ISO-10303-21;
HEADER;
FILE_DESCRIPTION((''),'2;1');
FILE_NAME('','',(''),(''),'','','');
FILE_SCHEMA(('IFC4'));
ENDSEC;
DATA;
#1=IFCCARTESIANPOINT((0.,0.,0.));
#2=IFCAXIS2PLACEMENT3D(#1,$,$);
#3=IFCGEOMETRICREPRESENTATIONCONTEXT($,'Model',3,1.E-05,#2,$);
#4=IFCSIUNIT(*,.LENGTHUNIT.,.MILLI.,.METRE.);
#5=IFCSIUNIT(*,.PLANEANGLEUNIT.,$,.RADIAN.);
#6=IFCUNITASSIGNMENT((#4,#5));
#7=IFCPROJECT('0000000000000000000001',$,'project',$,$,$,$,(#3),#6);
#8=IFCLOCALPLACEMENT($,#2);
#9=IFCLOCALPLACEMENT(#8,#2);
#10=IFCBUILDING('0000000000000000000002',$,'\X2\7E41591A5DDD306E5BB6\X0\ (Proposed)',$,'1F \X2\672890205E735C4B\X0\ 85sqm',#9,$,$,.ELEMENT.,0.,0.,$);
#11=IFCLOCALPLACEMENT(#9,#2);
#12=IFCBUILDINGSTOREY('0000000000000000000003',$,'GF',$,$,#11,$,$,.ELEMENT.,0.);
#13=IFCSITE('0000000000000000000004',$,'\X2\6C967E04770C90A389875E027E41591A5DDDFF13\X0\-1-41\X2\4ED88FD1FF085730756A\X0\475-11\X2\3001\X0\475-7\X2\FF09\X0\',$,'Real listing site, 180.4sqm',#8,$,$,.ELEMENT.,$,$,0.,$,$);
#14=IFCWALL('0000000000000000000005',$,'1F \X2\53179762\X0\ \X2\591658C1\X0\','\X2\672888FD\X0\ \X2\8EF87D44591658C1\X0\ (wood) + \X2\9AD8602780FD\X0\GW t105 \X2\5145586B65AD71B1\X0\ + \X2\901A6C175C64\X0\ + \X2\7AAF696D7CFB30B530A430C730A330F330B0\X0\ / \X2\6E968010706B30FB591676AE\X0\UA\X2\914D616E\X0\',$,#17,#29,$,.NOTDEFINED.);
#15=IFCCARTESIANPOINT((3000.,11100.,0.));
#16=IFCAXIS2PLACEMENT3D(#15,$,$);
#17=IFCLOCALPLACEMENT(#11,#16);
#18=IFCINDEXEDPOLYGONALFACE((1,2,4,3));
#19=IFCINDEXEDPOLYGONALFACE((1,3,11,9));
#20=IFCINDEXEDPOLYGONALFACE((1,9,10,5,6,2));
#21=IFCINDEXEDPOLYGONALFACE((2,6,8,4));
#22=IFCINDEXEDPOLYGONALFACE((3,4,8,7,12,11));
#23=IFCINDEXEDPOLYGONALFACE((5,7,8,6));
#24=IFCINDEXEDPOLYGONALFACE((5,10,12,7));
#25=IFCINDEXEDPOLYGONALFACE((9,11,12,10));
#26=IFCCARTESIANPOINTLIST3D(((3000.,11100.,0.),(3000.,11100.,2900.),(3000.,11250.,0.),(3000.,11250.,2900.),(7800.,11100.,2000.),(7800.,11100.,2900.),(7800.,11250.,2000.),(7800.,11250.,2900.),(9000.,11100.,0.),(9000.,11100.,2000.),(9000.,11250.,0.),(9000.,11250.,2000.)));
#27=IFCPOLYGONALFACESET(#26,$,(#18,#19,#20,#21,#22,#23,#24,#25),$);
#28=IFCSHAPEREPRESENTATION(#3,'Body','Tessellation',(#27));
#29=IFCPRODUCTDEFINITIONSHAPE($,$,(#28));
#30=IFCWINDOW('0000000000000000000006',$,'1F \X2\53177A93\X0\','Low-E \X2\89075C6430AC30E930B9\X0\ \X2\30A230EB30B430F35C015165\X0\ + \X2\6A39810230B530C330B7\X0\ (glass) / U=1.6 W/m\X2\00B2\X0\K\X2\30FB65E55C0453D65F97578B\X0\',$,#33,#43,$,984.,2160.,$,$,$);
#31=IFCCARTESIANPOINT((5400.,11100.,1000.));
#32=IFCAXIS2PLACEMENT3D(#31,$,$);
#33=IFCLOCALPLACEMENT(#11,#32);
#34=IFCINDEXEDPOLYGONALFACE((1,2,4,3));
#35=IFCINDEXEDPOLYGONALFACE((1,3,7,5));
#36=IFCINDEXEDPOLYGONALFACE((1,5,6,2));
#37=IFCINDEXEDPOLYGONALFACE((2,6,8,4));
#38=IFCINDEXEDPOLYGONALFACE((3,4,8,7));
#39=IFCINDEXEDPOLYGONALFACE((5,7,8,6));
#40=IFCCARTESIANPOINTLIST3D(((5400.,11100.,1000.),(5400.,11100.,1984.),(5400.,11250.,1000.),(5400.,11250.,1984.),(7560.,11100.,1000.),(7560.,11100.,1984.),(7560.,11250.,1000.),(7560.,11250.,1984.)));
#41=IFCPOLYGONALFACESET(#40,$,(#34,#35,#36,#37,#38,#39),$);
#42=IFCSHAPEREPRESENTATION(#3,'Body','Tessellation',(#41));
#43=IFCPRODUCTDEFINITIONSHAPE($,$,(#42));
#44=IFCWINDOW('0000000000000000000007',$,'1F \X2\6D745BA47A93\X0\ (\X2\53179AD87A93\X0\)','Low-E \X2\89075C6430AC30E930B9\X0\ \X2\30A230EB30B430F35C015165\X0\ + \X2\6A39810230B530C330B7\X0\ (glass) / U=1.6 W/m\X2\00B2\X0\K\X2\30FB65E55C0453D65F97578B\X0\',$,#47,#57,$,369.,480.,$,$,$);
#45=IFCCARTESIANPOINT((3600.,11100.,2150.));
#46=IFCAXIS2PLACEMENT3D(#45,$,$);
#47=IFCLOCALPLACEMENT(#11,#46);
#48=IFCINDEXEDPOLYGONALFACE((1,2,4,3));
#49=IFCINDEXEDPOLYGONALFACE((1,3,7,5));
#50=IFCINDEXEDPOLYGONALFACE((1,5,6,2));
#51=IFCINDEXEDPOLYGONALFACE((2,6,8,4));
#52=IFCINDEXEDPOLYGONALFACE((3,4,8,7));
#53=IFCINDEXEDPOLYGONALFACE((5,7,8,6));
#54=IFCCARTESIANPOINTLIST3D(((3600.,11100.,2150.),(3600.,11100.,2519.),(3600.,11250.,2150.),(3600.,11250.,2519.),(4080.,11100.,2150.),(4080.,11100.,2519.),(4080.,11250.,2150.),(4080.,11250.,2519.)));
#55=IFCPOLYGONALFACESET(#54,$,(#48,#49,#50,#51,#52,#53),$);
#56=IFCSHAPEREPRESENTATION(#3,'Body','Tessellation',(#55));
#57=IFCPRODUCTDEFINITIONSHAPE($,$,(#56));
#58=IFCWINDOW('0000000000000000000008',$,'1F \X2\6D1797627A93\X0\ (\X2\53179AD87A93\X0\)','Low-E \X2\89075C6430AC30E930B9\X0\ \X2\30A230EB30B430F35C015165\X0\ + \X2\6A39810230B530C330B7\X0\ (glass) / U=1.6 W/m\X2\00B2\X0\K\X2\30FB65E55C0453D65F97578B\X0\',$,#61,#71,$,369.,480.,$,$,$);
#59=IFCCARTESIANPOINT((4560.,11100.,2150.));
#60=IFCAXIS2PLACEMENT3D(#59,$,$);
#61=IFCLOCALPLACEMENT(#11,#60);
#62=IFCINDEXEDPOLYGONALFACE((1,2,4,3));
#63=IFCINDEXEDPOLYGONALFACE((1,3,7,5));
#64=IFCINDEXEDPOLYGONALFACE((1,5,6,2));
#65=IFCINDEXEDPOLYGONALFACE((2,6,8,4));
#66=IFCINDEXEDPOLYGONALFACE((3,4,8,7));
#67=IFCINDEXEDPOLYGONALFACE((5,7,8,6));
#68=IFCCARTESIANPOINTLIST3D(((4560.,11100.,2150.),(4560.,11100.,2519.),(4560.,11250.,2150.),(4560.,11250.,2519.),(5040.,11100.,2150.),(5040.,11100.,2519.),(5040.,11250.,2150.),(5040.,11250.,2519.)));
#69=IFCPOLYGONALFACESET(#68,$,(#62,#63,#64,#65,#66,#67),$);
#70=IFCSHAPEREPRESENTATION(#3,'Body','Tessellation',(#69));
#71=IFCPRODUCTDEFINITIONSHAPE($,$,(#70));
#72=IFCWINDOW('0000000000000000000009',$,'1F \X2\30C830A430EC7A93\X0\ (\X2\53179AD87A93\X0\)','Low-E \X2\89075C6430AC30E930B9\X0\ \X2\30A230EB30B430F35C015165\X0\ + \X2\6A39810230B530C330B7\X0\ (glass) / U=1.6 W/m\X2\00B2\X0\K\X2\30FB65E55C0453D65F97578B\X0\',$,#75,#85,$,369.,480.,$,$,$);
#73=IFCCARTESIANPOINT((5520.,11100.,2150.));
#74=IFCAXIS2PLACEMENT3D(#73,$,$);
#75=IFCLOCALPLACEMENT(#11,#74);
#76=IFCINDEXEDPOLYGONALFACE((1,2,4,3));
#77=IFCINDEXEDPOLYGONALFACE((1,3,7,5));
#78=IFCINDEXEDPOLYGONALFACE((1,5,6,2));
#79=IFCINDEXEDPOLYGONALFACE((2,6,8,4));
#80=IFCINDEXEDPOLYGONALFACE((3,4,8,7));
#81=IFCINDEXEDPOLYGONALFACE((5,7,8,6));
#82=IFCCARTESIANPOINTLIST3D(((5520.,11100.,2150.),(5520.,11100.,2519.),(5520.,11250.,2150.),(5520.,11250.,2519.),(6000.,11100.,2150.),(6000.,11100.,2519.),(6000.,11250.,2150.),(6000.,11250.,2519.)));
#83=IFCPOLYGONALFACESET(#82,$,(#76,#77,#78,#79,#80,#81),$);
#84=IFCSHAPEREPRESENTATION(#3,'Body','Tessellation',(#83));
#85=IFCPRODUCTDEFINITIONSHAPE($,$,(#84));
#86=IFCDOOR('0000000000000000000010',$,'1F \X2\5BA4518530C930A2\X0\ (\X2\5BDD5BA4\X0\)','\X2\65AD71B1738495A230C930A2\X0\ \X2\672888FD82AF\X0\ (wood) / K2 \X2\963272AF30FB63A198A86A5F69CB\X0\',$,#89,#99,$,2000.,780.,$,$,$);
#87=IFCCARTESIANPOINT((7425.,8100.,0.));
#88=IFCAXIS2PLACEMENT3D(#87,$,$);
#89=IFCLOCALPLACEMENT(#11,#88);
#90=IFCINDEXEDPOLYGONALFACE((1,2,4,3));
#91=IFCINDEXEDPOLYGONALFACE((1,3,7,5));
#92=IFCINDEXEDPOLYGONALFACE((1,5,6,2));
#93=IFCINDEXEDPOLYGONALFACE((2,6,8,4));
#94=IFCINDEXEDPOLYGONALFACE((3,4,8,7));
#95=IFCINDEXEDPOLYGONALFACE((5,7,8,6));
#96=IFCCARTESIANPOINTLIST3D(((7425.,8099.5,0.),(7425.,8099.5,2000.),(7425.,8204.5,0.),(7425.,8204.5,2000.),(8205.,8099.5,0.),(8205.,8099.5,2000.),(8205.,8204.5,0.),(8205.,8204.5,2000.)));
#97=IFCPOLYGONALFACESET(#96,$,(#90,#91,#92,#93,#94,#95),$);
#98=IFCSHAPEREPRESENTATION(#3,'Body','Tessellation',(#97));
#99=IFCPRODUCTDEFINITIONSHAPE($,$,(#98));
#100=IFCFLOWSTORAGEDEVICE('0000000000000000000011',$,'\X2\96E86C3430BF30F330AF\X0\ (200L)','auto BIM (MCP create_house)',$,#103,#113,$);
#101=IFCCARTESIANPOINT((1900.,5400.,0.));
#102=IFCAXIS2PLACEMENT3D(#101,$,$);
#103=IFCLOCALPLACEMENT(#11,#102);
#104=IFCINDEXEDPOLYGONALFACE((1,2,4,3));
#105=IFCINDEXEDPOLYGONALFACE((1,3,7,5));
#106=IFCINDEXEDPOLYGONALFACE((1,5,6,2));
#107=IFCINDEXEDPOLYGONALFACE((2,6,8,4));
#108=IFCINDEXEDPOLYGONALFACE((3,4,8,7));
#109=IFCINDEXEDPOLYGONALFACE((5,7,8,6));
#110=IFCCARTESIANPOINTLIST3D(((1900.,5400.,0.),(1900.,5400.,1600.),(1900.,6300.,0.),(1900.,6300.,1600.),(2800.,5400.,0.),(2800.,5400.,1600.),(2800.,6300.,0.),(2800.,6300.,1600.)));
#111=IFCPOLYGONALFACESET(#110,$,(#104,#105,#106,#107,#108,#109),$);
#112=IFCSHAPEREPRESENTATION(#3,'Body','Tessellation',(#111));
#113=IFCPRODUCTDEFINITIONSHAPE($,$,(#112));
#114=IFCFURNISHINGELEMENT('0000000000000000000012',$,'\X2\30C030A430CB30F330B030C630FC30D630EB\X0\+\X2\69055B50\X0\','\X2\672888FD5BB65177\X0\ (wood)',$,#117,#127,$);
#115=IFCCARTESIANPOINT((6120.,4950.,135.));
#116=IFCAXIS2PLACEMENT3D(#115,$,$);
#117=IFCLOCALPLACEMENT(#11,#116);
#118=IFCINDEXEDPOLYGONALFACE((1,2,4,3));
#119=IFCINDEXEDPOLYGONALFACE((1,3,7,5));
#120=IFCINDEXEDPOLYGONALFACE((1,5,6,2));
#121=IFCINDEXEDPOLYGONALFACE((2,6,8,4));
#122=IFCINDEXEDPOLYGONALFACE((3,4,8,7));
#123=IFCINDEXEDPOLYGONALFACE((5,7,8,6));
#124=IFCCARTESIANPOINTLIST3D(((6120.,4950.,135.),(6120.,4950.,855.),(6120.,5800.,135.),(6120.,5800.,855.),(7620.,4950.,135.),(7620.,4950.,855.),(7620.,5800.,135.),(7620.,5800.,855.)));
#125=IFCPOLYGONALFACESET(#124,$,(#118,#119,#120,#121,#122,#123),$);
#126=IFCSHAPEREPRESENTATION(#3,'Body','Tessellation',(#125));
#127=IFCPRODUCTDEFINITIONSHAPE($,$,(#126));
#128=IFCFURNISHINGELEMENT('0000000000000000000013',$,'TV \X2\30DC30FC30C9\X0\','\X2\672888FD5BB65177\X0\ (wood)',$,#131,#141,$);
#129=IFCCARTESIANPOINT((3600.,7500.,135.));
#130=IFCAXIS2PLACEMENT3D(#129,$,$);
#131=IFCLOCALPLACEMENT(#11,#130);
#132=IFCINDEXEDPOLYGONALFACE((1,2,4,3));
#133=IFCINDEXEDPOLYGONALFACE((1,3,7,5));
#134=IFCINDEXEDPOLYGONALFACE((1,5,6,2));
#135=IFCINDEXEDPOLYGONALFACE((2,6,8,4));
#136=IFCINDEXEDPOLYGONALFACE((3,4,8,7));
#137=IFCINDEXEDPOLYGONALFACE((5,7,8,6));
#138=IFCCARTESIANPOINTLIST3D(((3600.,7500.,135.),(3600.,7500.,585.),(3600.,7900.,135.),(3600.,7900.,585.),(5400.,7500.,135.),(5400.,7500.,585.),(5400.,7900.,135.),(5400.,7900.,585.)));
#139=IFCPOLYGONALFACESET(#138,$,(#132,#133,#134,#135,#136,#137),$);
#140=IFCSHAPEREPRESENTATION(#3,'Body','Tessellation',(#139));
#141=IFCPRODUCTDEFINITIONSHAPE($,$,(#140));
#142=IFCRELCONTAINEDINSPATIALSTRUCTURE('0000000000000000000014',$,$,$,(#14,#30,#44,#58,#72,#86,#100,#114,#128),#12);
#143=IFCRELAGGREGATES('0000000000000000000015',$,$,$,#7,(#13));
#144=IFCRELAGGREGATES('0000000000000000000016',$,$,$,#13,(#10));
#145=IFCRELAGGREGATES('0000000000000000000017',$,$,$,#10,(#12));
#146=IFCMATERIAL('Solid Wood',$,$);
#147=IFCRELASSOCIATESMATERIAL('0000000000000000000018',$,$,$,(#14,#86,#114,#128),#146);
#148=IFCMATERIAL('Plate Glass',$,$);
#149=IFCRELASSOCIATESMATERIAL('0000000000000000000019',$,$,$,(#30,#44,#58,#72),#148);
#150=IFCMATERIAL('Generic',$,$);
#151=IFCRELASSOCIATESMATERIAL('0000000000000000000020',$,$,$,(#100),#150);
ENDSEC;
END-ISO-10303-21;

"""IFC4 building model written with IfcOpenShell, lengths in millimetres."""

from ifc_helpers import new_model, si_unit, frame, frame_2d, origin, place, context, project, spatial, rectangle, extrude, material, element, fill, save


model = new_model("IFC4")

# Units and contexts
model_context = context("Model", 3, precision=1e-05, world=origin())
ifc_project = project(units=[si_unit("LENGTHUNIT", "METRE", prefix="MILLI"), si_unit("PLANEANGLEUNIT", "RADIAN")], contexts=[model_context])

# Site, building, storey
site_placement = place(None, origin())
site = spatial("IfcSite", under=ifc_project, at=site_placement, Name="沖縄県那覇市繁多川３-1-41付近（地番475-11、475-7）", ObjectType="Real listing site, 180.4sqm", CompositionType="ELEMENT", RefElevation=0.0)
building_placement = place(site_placement, origin())
building = spatial("IfcBuilding", under=site, at=building_placement, Name="繁多川の家 (Proposed)", ObjectType="1F 木造平屋 85sqm", CompositionType="ELEMENT", ElevationOfRefHeight=0.0, ElevationOfTerrain=0.0)
storey_placement = place(building_placement, origin())
storey = spatial("IfcBuildingStorey", under=building, at=storey_placement, Name="GF", CompositionType="ELEMENT", Elevation=0.0)

# Wall, openings, windows
ifc_material_1 = material(Name="Solid Wood")
wall_1_placement = place(storey_placement, frame((3000.0, 11100.0, 0.0)))
wall_1 = element("IfcWall", 1, at=wall_1_placement, inside=storey, material=ifc_material_1, Name="1F 北面 外壁", Description="木製 軸組外壁 (wood) + 高性能GW t105 充填断熱 + 通気層 + 窯業系サイディング / 準耐火・外皮UA配慮", PredefinedType="NOTDEFINED", context=model_context, shape_type="SweptSolid", body=[
    extrude(rectangle(XDim=6000.0, YDim=150.0, at=frame_2d((3000.0, 75.0))), frame((3000.0, 11100.0, 0.0)), (0.0, 0.0, 1.0), 2900.0),
])
opening_1_placement = place(storey_placement, frame((5400.0, 11100.0, 1000.0)))
opening_1 = element("IfcOpeningElement", 2, at=opening_1_placement, cuts=wall_1, PredefinedType="NOTDEFINED", context=model_context, shape_type="SweptSolid", body=[
    extrude(rectangle(XDim=2160.0, YDim=150.0, at=frame_2d((1080.0, 75.0))), frame((5400.0, 11100.0, 1000.0)), (0.0, 0.0, 1.0), 984.0),
])
opening_2_placement = place(storey_placement, frame((3600.0, 11100.0, 2150.0)))
opening_2 = element("IfcOpeningElement", 3, at=opening_2_placement, cuts=wall_1, PredefinedType="NOTDEFINED", context=model_context, shape_type="SweptSolid", body=[
    extrude(rectangle(XDim=480.0, YDim=150.0, at=frame_2d((240.0, 75.0))), frame((3600.0, 11100.0, 2150.0)), (0.0, 0.0, 1.0), 369.0),
])
opening_3_placement = place(storey_placement, frame((4560.0, 11100.0, 2150.0)))
opening_3 = element("IfcOpeningElement", 4, at=opening_3_placement, cuts=wall_1, PredefinedType="NOTDEFINED", context=model_context, shape_type="SweptSolid", body=[
    extrude(rectangle(XDim=480.0, YDim=150.0, at=frame_2d((240.0, 75.0))), frame((4560.0, 11100.0, 2150.0)), (0.0, 0.0, 1.0), 369.0),
])
opening_4_placement = place(storey_placement, frame((5520.0, 11100.0, 2150.0)))
opening_4 = element("IfcOpeningElement", 5, at=opening_4_placement, cuts=wall_1, PredefinedType="NOTDEFINED", context=model_context, shape_type="SweptSolid", body=[
    extrude(rectangle(XDim=480.0, YDim=150.0, at=frame_2d((240.0, 75.0))), frame((5520.0, 11100.0, 2150.0)), (0.0, 0.0, 1.0), 369.0),
])
ifc_material_2 = material(Name="Plate Glass")
window_1_placement = place(storey_placement, frame((5400.0, 11100.0, 1000.0)))
window_1 = element("IfcWindow", 6, at=window_1_placement, inside=storey, material=ifc_material_2, Name="1F 北窓", Description="Low-E 複層ガラス アルゴン封入 + 樹脂サッシ (glass) / U=1.6 W/m²K・日射取得型", OverallHeight=984.0, OverallWidth=2160.0, context=model_context, shape_type="SweptSolid", body=[
    extrude(rectangle(XDim=2160.0, YDim=150.0, at=frame_2d((1080.0, 75.0))), frame((5400.0, 11100.0, 1000.0)), (0.0, 0.0, 1.0), 984.0),
])
fill(opening_1, window_1)
window_2_placement = place(storey_placement, frame((3600.0, 11100.0, 2150.0)))
window_2 = element("IfcWindow", 7, at=window_2_placement, inside=storey, material=ifc_material_2, Name="1F 浴室窓 (北高窓)", Description="Low-E 複層ガラス アルゴン封入 + 樹脂サッシ (glass) / U=1.6 W/m²K・日射取得型", OverallHeight=369.0, OverallWidth=480.0, context=model_context, shape_type="SweptSolid", body=[
    extrude(rectangle(XDim=480.0, YDim=150.0, at=frame_2d((240.0, 75.0))), frame((3600.0, 11100.0, 2150.0)), (0.0, 0.0, 1.0), 369.0),
])
fill(opening_2, window_2)
window_3_placement = place(storey_placement, frame((4560.0, 11100.0, 2150.0)))
window_3 = element("IfcWindow", 8, at=window_3_placement, inside=storey, material=ifc_material_2, Name="1F 洗面窓 (北高窓)", Description="Low-E 複層ガラス アルゴン封入 + 樹脂サッシ (glass) / U=1.6 W/m²K・日射取得型", OverallHeight=369.0, OverallWidth=480.0, context=model_context, shape_type="SweptSolid", body=[
    extrude(rectangle(XDim=480.0, YDim=150.0, at=frame_2d((240.0, 75.0))), frame((4560.0, 11100.0, 2150.0)), (0.0, 0.0, 1.0), 369.0),
])
fill(opening_3, window_3)
window_4_placement = place(storey_placement, frame((5520.0, 11100.0, 2150.0)))
window_4 = element("IfcWindow", 9, at=window_4_placement, inside=storey, material=ifc_material_2, Name="1F トイレ窓 (北高窓)", Description="Low-E 複層ガラス アルゴン封入 + 樹脂サッシ (glass) / U=1.6 W/m²K・日射取得型", OverallHeight=369.0, OverallWidth=480.0, context=model_context, shape_type="SweptSolid", body=[
    extrude(rectangle(XDim=480.0, YDim=150.0, at=frame_2d((240.0, 75.0))), frame((5520.0, 11100.0, 2150.0)), (0.0, 0.0, 1.0), 369.0),
])
fill(opening_4, window_4)

# Door
door_1_placement = place(storey_placement, frame((7425.0, 8100.0, 0.0)))
element("IfcDoor", 10, at=door_1_placement, inside=storey, material=ifc_material_1, Name="1F 室内ドア (寝室)", Description="断熱玄関ドア 木製芯 (wood) / K2 防犯・採風機構", OverallHeight=2000.0, OverallWidth=780.0, context=model_context, shape_type="SweptSolid", body=[
    extrude(rectangle(XDim=780.0, YDim=105.0, at=frame_2d((390.0, 52.0))), frame((7425.0, 8100.0, 0.0)), (0.0, 0.0, 1.0), 2000.0),
])

# Flow storage device
ifc_material_3 = material(Name="Generic")
flow_storage_device_placement = place(storey_placement, frame((1900.0, 5400.0, 0.0)))
element("IfcFlowStorageDevice", 11, at=flow_storage_device_placement, inside=storey, material=ifc_material_3, Name="雨水タンク (200L)", Description="auto BIM (MCP create_house)", context=model_context, shape_type="SweptSolid", body=[
    extrude(rectangle(XDim=900.0, YDim=900.0, at=frame_2d((450.0, 450.0))), frame((1900.0, 5400.0, 0.0)), (0.0, 0.0, 1.0), 1600.0),
])

# Furnishing elements
furnishing_1_placement = place(storey_placement, frame((6120.0, 4950.0, 135.0)))
element("IfcFurnishingElement", 12, at=furnishing_1_placement, inside=storey, material=ifc_material_1, Name="ダイニングテーブル+椅子", Description="木製家具 (wood)", context=model_context, shape_type="SweptSolid", body=[
    extrude(rectangle(XDim=1500.0, YDim=850.0, at=frame_2d((750.0, 425.0))), frame((6120.0, 4950.0, 135.0)), (0.0, 0.0, 1.0), 720.0),
])
furnishing_2_placement = place(storey_placement, frame((3600.0, 7500.0, 135.0)))
element("IfcFurnishingElement", 13, at=furnishing_2_placement, inside=storey, material=ifc_material_1, Name="TV ボード", Description="木製家具 (wood)", context=model_context, shape_type="SweptSolid", body=[
    extrude(rectangle(XDim=1800.0, YDim=400.0, at=frame_2d((900.0, 200.0))), frame((3600.0, 7500.0, 135.0)), (0.0, 0.0, 1.0), 450.0),
])

save(model, "model.ifc")
